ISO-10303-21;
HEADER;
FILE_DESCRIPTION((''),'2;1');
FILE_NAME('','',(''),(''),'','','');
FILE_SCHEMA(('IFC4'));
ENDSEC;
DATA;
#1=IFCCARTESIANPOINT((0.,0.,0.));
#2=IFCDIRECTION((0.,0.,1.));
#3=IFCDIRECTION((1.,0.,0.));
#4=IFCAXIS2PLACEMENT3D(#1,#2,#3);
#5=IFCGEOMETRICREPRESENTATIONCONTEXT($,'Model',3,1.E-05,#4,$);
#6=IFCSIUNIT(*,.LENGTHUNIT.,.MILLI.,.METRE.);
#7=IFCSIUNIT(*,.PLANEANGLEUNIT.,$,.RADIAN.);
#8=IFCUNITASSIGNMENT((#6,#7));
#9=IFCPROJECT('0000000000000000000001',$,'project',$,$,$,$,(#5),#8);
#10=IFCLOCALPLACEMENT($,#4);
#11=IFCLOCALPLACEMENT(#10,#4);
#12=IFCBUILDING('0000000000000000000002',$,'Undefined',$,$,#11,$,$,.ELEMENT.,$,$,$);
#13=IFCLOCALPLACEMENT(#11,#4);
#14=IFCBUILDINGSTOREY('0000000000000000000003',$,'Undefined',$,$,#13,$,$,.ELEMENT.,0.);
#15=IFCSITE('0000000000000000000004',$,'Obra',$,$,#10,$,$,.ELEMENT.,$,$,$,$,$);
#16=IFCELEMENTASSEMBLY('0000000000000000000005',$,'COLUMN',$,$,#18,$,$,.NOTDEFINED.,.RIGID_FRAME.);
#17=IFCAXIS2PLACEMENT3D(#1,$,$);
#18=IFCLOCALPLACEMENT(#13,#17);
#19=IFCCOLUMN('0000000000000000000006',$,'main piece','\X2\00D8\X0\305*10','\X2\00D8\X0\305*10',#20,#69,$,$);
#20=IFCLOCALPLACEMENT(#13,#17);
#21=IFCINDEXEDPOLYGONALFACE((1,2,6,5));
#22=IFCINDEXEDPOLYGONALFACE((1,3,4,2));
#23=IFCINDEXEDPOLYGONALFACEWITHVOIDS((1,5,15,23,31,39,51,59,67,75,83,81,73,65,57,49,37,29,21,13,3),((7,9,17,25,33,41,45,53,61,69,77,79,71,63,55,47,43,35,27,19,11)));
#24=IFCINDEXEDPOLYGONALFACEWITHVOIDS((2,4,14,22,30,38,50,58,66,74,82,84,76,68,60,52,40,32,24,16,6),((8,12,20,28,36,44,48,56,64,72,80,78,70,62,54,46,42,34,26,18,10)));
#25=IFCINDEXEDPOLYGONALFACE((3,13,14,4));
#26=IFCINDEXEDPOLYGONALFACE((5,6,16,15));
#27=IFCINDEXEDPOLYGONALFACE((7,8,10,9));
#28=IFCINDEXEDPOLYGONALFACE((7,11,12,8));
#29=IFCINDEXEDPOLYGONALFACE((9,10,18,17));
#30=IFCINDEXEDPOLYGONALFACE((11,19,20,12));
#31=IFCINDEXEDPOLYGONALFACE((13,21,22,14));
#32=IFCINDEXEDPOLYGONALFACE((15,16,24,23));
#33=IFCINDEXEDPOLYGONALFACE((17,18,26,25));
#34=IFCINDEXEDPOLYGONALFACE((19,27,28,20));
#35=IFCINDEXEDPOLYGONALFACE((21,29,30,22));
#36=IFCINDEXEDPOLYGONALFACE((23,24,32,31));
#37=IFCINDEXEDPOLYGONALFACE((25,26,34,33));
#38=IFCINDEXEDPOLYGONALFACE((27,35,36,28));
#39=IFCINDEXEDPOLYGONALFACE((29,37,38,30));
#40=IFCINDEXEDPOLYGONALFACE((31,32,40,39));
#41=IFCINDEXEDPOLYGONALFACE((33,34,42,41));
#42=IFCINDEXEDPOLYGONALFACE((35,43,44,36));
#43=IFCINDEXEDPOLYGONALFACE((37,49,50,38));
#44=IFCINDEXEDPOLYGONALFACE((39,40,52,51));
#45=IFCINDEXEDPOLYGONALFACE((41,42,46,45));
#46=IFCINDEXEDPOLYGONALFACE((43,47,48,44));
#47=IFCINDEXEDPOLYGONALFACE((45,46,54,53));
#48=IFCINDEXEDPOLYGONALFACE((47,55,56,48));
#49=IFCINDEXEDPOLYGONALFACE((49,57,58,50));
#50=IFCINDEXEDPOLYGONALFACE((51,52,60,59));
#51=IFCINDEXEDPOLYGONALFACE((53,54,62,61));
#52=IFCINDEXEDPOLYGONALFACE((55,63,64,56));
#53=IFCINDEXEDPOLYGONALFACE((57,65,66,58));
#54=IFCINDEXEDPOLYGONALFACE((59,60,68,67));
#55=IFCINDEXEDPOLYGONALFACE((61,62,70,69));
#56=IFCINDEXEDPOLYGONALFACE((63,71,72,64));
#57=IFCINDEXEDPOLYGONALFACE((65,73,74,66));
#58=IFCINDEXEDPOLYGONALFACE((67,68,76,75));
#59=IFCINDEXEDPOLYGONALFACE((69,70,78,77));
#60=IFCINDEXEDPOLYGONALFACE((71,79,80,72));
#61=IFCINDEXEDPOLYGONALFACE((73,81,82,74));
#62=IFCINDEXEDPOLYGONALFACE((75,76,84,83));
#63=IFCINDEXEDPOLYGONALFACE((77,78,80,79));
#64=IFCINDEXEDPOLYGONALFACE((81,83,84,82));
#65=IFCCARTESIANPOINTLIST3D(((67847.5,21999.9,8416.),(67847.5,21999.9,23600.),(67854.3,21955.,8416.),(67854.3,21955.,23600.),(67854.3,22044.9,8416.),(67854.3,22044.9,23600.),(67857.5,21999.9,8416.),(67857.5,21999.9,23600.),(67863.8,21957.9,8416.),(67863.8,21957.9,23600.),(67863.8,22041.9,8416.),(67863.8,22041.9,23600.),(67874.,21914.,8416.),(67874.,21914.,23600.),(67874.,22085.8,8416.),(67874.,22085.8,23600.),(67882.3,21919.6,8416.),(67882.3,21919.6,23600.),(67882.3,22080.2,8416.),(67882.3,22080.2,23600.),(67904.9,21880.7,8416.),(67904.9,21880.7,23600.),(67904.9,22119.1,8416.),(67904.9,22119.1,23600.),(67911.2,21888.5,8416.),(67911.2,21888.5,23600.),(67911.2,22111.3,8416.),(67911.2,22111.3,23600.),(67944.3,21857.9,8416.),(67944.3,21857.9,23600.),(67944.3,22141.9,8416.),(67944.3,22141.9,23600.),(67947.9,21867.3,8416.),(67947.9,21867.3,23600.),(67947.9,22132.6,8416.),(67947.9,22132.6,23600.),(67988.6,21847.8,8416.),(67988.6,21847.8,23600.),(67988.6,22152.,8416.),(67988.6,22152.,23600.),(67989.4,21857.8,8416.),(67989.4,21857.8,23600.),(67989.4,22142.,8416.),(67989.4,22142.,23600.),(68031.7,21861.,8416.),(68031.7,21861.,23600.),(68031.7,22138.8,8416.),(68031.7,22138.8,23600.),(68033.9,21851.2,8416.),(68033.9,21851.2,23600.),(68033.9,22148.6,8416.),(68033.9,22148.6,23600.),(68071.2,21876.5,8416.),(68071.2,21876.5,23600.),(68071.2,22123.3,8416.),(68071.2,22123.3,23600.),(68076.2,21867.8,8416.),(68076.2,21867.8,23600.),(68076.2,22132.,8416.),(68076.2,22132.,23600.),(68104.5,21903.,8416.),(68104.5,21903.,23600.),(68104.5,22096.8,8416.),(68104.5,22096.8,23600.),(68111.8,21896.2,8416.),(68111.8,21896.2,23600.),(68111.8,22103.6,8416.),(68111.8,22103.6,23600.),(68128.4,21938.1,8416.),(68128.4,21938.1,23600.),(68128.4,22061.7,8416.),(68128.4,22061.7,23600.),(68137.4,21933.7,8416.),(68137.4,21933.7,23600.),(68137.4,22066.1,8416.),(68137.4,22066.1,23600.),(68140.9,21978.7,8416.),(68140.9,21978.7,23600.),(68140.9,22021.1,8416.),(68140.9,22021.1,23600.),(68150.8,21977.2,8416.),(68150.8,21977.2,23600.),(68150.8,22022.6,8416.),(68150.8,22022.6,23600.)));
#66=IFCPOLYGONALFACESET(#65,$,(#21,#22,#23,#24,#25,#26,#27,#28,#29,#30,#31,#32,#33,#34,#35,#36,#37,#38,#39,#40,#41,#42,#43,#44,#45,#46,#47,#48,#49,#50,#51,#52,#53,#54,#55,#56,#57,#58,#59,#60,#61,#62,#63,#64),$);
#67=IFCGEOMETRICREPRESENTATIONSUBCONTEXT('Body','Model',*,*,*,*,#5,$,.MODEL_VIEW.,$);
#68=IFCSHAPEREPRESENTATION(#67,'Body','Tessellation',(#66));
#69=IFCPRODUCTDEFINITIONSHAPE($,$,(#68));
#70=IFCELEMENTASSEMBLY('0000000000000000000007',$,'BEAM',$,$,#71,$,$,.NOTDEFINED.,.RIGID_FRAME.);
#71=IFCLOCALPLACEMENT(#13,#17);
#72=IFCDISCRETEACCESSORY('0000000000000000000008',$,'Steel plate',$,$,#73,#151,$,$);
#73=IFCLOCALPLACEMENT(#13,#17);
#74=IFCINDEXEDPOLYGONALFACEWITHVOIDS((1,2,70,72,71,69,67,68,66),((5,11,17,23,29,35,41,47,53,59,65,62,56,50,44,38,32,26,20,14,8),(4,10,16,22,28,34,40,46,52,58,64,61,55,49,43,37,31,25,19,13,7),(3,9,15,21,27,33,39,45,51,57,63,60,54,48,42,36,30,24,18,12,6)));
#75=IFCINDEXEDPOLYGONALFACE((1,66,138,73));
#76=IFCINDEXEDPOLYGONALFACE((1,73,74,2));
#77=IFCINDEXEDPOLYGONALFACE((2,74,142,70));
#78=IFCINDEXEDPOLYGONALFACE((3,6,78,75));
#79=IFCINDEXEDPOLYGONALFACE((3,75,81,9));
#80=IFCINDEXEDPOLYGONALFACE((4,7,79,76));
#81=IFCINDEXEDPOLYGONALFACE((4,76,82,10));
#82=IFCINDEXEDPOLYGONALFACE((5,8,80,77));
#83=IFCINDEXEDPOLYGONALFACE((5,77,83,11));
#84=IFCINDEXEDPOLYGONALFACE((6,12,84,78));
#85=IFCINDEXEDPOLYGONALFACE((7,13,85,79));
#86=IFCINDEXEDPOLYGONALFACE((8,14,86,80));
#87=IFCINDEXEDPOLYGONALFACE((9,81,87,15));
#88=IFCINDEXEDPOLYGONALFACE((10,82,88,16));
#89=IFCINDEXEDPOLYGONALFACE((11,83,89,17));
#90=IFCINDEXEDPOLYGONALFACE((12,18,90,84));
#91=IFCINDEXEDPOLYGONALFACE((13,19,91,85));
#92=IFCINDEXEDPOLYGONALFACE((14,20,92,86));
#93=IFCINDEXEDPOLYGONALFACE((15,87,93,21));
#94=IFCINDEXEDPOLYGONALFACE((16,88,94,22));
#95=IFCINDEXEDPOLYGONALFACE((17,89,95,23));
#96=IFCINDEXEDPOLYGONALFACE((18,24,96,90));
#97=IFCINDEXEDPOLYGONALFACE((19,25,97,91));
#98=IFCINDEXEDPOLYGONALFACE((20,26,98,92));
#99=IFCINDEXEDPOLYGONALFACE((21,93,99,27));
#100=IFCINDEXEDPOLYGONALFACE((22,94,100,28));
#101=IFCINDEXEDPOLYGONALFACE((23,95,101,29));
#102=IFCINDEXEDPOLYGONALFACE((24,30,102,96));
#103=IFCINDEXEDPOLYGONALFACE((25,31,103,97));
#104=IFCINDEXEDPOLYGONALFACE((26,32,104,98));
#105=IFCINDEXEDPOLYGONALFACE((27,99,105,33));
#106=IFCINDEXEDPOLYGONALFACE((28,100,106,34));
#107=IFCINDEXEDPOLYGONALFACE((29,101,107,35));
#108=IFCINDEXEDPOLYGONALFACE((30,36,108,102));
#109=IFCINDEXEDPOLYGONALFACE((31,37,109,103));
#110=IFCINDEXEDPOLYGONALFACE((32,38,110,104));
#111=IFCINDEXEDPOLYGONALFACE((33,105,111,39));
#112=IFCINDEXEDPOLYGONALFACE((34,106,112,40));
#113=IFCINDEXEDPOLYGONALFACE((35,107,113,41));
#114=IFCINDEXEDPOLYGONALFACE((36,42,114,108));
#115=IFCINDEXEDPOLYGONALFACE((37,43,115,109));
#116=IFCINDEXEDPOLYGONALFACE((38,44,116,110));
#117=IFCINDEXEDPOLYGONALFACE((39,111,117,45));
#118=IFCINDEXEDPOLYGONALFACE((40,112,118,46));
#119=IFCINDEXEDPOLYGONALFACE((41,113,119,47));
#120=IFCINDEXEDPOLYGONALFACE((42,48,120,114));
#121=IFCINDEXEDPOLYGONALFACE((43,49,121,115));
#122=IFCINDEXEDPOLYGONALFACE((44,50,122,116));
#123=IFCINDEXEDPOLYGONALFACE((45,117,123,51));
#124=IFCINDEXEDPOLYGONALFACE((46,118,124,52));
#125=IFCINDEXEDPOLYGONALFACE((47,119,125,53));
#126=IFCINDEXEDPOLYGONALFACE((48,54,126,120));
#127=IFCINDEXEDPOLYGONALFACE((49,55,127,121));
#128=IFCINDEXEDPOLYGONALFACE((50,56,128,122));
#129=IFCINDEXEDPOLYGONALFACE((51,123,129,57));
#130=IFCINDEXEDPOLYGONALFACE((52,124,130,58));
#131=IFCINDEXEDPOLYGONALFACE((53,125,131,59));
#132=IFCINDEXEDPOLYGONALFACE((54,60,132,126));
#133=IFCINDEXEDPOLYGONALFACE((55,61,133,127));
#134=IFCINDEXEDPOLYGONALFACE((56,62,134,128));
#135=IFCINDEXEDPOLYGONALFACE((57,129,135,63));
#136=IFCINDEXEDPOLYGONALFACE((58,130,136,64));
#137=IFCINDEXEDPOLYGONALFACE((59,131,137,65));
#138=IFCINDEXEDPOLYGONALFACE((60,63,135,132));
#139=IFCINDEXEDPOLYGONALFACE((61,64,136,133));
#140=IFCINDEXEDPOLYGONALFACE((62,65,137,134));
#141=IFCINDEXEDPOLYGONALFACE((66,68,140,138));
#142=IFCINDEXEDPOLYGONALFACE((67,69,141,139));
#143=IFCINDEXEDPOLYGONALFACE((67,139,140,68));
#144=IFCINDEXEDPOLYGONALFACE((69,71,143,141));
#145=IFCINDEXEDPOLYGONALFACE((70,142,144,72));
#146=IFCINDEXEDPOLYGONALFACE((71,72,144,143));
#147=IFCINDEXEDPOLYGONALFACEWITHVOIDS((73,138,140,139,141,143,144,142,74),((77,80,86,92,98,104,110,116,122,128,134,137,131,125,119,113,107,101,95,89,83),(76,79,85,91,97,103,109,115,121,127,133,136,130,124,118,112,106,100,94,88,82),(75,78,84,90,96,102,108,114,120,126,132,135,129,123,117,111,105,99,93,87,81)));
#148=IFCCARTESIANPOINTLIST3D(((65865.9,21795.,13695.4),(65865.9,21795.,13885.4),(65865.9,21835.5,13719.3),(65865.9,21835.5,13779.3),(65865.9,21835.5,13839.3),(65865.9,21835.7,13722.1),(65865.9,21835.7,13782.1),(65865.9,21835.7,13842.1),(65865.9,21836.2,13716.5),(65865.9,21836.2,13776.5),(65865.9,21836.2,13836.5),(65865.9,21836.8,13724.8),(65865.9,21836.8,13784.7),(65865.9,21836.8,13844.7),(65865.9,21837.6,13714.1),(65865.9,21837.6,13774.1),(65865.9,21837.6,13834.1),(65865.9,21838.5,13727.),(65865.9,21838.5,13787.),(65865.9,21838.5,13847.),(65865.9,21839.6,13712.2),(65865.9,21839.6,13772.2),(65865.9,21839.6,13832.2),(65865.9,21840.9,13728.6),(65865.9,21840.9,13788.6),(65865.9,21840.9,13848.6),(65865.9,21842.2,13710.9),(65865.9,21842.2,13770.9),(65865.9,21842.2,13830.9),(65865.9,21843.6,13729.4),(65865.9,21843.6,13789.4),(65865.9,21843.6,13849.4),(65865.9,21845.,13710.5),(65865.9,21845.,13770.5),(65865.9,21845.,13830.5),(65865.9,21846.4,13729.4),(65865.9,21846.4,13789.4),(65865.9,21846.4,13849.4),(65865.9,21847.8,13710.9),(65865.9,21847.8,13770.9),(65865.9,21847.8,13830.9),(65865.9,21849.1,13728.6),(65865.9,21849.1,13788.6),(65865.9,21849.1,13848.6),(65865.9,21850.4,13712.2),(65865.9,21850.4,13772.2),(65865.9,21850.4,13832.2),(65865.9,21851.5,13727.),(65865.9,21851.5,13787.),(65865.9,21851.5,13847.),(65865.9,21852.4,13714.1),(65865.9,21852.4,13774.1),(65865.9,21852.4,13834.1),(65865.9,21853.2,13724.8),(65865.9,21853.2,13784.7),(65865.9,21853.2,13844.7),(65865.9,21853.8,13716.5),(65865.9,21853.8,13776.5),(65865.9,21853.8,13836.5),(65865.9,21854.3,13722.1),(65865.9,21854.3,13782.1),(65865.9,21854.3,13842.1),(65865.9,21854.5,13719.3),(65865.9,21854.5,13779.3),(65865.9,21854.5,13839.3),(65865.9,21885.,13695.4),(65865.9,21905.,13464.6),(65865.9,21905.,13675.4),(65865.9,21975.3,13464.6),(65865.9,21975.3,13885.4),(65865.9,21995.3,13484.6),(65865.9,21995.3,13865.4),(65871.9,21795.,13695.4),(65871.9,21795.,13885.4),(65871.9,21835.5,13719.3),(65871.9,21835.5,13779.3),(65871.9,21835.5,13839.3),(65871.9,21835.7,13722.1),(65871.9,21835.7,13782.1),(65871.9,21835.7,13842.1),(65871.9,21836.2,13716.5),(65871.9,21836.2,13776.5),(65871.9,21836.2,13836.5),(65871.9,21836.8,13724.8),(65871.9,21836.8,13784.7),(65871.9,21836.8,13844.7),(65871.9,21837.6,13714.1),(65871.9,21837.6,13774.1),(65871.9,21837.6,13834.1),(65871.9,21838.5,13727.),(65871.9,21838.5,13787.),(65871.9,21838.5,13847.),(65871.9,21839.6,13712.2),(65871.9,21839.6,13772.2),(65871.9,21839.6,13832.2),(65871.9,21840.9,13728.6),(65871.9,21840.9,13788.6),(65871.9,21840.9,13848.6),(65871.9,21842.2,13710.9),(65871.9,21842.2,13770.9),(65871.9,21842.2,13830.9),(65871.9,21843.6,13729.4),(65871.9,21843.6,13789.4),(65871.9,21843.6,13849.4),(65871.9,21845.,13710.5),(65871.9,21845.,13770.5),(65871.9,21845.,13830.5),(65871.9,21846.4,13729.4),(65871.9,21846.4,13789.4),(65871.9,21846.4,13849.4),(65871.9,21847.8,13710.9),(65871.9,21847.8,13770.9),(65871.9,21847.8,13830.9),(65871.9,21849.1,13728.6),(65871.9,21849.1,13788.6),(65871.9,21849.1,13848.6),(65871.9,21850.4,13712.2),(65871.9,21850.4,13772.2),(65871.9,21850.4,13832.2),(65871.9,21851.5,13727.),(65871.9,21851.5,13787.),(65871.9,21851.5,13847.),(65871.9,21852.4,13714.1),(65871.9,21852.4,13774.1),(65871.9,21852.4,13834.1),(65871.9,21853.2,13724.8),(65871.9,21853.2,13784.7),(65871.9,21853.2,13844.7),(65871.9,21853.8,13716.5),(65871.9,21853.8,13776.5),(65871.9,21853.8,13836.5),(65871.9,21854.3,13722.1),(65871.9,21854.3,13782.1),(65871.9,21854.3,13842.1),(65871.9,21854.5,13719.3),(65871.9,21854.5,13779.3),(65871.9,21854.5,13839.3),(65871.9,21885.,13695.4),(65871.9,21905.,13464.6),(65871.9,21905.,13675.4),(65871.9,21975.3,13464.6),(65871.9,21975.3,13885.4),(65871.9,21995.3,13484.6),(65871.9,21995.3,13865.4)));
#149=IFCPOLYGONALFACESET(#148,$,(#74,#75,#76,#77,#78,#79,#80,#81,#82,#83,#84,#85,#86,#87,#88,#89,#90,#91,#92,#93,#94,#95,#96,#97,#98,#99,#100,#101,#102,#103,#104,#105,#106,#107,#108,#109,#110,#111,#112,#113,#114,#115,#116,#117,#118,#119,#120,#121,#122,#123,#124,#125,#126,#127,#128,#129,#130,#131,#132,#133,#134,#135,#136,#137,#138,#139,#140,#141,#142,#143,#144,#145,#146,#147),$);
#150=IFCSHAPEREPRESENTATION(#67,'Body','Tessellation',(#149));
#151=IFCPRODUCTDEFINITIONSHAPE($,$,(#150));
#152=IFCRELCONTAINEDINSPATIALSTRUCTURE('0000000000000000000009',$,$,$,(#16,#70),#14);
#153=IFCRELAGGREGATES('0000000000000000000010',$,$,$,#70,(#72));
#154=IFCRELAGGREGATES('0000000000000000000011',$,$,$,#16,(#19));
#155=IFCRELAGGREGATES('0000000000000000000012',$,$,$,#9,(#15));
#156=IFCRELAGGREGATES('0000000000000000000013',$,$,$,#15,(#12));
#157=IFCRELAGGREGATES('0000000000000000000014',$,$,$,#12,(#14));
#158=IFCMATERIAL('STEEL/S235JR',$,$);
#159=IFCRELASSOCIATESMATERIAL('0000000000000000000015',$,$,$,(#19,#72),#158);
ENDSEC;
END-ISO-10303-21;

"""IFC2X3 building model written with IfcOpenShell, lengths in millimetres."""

from ifc_helpers import new_model, si_unit, frame, origin_with_axes, origin_2d_with_axis, place, context, subcontext, project, spatial, polyline, circle, hollow_circle, outline, extrude, clip, halfspace, source, transform, mapped, material, element, aggregate, save


model = new_model("IFC2X3")

# Units and contexts
model_context = context("Model", 3, precision=1e-05, world=origin_with_axes())
body_context = subcontext(model_context, "Body", "Model", "MODEL_VIEW")
ifc_project = project(units=[si_unit("LENGTHUNIT", "METRE", prefix="MILLI"), si_unit("PLANEANGLEUNIT", "RADIAN")], contexts=[model_context])

# Site, building, storey
site_placement = place(None, origin_with_axes())
site = spatial("IfcSite", under=ifc_project, at=site_placement, Name="Obra", CompositionType="ELEMENT")
building_placement = place(site_placement, origin_with_axes())
building = spatial("IfcBuilding", under=site, at=building_placement, Name="Undefined", CompositionType="ELEMENT")
storey_placement = place(building_placement, origin_with_axes())
storey = spatial("IfcBuildingStorey", under=building, at=storey_placement, Name="Undefined", CompositionType="ELEMENT", Elevation=0.0)

# Element assembly, column
assembly_1_placement = place(storey_placement, origin_with_axes())
assembly_1 = element("IfcElementAssembly", 1, at=assembly_1_placement, inside=storey, Name="COLUMN", AssemblyPlace="NOTDEFINED", PredefinedType="RIGID_FRAME")
ifc_material_1 = material(Name="STEEL/S235JR")
column_placement = place(assembly_1_placement, frame((68000.0, 21999.9, 8400.0), z_axis=(0.0, 0.0, 1.0), x_axis=(0.0, 1.0, 0.0)))
column = element("IfcColumn", 2, at=column_placement, material=ifc_material_1, Name="main piece", Description="Ø305*10", ObjectType="Ø305*10", context=body_context, shape_type="Clipping", body=[
    clip(extrude(hollow_circle(Radius=152.5, WallThickness=10.0, at=origin_2d_with_axis()), frame((0.0, 0.0, 15200.0), z_axis=(0.0, 0.0, -1.0), x_axis=(0.0, 1.0, 0.0)), (0.0, 0.0, 1.0), 15184.0), halfspace(frame((-152.5, 0.0, 16.0), z_axis=(0.0, 0.0, 1.0), x_axis=(0.0, 1.0, 0.0)), True)),
])

# Element assembly
assembly_2_placement = place(storey_placement, origin_with_axes())
assembly_2 = element("IfcElementAssembly", 3, at=assembly_2_placement, inside=storey, Name="BEAM", AssemblyPlace="NOTDEFINED", PredefinedType="RIGID_FRAME")

# Discrete accessory, opening
discrete_accessory_1_placement = place(assembly_2_placement, frame((65868.9, 21995.3, 13484.6), z_axis=(-1.0, 0.0, 0.0), x_axis=(0.000001, -0.707107, -0.707107)))
discrete_accessory_1 = element("IfcDiscreteAccessory", 4, at=discrete_accessory_1_placement, material=ifc_material_1, Name="Steel plate", context=body_context, shape_type="SweptSolid", body=[
    extrude(outline(polyline([(0.0, 0.0), (28.3, 0.0), (78.0, 49.7), (-71.1, 198.8), (-71.1, 227.1), (-7.4, 290.7), (-141.8, 425.0), (-269.3, 297.6), (-269.3, 269.3), (0.0, 0.0)])), frame((0.0, 0.0, -3.0), z_axis=(0.0, 0.0, 1.0), x_axis=(1.0, 0.0, 0.0)), (0.0, 0.0, 1.0), 6.0),
])
shared_shape_1 = source(origin_with_axes(), body_context, "Body", "SweptSolid", [
    extrude(circle(Radius=9.5, at=origin_2d_with_axis()), frame((0.0, -9.2, 0.0), z_axis=(0.0, 1.0, 0.0), x_axis=(1.0, 0.0, 0.0)), (0.0, 0.0, 1.0), 6.2),
])
opening_1_placement = place(assembly_2_placement, frame((65875.0, 21895.0, 13885.4), z_axis=(0.0, -1.0, 0.0), x_axis=(0.0, 0.0, -1.0)))
element("IfcOpeningElement", 5, at=opening_1_placement, cuts=discrete_accessory_1, ObjectType="Opening", context=body_context, shape_type="MappedRepresentation", body=[
    mapped(shared_shape_1, transform((165.4, 0.0, 50.0))),
    mapped(shared_shape_1, transform((105.4, 0.0, 50.0))),
    mapped(shared_shape_1, transform((45.4, 0.0, 50.0))),
])
aggregate(assembly_2, [discrete_accessory_1])

aggregate(assembly_1, [column])

save(model, "model.ifc")
